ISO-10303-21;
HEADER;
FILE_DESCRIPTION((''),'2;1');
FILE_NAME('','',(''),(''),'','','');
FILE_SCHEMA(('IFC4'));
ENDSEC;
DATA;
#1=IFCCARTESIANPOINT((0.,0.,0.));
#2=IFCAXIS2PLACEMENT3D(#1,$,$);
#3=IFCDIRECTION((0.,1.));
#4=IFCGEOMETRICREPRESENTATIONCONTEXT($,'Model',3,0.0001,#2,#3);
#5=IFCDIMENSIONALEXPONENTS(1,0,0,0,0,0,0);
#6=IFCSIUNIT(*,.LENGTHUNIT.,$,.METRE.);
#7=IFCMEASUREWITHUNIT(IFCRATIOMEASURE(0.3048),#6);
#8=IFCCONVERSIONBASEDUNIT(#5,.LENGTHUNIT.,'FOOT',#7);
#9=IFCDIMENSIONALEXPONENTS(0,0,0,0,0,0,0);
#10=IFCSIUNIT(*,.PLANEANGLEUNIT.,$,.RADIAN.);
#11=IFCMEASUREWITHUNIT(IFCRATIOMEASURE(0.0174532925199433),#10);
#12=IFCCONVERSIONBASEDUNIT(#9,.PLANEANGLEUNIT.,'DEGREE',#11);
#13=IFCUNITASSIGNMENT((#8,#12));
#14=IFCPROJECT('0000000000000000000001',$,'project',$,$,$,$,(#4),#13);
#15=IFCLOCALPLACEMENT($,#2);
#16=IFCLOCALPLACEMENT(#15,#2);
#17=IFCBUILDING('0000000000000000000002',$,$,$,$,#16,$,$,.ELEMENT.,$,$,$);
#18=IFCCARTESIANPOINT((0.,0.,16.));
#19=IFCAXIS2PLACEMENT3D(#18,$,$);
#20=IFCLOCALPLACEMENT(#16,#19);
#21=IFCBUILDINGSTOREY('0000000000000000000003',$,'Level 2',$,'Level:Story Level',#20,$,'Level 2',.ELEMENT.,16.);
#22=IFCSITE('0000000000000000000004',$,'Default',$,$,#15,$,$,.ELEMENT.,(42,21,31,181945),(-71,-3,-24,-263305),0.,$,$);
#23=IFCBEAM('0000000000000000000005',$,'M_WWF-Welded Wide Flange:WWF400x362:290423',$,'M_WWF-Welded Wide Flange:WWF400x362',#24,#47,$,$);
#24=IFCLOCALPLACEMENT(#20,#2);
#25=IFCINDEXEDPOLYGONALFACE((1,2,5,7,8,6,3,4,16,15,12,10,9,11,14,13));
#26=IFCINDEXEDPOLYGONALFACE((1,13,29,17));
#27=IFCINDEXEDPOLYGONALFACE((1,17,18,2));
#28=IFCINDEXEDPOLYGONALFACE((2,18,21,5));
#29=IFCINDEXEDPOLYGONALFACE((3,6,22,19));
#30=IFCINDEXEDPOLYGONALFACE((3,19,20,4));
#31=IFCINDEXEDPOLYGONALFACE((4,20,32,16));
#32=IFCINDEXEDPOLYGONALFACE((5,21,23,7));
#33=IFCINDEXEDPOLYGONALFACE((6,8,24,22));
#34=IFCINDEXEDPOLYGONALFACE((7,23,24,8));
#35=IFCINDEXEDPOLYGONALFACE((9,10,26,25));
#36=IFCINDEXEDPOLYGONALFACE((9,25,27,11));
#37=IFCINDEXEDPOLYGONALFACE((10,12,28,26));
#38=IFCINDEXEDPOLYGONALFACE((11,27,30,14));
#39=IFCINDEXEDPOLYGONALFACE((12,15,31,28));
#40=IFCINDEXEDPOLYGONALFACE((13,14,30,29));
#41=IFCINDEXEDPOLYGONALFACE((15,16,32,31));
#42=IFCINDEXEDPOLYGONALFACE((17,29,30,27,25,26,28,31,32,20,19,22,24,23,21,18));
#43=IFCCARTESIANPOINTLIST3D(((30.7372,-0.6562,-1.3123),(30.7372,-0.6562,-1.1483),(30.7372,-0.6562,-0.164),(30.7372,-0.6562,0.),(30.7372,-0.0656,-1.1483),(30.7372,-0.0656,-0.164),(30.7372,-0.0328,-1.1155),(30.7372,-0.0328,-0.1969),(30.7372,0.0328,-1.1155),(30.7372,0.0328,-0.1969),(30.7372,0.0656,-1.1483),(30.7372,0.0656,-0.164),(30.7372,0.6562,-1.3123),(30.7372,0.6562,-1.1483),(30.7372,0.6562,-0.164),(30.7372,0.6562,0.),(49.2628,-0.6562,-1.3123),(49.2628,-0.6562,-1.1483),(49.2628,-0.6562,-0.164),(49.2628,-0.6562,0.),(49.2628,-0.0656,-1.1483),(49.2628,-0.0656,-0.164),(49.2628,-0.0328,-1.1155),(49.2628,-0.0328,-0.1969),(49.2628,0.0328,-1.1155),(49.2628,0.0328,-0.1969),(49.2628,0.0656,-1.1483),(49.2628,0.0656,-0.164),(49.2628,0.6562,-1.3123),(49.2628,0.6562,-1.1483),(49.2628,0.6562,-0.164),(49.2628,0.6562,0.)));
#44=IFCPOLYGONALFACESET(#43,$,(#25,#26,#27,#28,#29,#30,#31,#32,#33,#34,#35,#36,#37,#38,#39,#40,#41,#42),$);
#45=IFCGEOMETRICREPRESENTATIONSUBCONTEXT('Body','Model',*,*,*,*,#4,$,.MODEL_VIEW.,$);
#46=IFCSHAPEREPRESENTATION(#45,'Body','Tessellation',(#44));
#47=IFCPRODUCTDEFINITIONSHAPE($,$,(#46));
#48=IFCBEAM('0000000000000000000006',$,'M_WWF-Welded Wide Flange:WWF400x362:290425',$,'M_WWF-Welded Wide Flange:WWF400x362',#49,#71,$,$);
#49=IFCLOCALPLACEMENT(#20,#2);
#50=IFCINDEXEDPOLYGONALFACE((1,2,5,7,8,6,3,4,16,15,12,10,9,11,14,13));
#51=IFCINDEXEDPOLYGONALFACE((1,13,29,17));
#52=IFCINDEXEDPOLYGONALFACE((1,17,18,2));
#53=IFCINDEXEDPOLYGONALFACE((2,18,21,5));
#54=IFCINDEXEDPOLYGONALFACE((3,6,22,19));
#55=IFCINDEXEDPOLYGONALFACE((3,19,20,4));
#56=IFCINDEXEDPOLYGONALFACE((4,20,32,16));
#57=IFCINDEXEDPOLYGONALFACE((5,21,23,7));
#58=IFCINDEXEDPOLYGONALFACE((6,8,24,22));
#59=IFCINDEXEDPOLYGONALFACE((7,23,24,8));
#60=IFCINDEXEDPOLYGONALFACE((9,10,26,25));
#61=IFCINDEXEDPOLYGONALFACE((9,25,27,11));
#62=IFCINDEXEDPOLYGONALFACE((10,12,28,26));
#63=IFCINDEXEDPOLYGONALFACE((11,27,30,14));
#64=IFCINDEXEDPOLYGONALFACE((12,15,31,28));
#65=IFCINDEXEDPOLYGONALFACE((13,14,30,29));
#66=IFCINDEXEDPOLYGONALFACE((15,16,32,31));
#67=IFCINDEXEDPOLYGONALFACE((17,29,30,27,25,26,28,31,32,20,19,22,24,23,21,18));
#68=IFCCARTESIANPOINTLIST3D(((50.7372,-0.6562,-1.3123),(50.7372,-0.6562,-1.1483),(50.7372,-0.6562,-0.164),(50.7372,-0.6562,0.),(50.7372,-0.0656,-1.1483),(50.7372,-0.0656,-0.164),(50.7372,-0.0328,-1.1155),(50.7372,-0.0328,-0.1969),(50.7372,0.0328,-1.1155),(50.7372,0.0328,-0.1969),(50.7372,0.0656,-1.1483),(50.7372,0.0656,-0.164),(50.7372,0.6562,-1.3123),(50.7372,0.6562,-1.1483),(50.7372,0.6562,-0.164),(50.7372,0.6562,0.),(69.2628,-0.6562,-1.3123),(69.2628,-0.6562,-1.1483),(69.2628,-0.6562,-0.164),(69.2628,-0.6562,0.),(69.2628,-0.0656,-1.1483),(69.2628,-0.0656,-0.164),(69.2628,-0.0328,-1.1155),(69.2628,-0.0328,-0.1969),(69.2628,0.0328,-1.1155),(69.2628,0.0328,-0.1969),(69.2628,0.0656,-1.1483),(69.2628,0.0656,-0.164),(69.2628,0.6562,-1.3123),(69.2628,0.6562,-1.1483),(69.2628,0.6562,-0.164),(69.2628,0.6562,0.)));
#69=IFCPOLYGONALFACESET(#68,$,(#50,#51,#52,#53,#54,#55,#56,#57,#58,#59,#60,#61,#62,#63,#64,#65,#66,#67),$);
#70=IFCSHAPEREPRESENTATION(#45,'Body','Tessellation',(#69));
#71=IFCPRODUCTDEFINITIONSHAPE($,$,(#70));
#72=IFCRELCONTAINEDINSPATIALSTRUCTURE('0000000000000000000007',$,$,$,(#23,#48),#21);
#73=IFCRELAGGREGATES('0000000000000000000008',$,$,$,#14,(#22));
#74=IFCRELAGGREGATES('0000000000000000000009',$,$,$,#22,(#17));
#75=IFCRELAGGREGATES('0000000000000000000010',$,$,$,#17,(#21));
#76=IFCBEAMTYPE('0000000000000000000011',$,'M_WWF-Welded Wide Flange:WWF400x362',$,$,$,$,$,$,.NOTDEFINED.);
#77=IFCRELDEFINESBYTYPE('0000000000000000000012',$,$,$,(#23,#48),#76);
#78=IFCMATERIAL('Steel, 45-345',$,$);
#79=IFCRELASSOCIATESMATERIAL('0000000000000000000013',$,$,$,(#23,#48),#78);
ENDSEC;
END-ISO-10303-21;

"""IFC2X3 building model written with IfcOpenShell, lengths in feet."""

from ifc_helpers import new_model, entity, si_unit, converted_unit, direction, frame, origin, place, context, subcontext, project, spatial, polyline, outline, extrude, material, type_object, element, save


model = new_model("IFC2X3")

# Units and contexts
model_context = context("Model", 3, precision=0.0001, world=origin(), true_north=direction((0.0, 1.0)))
body_context = subcontext(model_context, "Body", "Model", "MODEL_VIEW")
ifc_project = project(units=[converted_unit("LENGTHUNIT", "FOOT", entity("IfcRatioMeasure", 0.3048), si_unit("LENGTHUNIT", "METRE"), dimensions=[1, 0, 0, 0, 0, 0, 0]), converted_unit("PLANEANGLEUNIT", "DEGREE", entity("IfcRatioMeasure", 0.0174532925199433), si_unit("PLANEANGLEUNIT", "RADIAN"), dimensions=[0, 0, 0, 0, 0, 0, 0])], contexts=[model_context])

# Site, building, storey
site_placement = place(None, origin())
site = spatial("IfcSite", under=ifc_project, at=site_placement, Name="Default", CompositionType="ELEMENT", RefLatitude=(42, 21, 31, 181945), RefLongitude=(-71, -3, -24, -263305), RefElevation=0.0)
building_placement = place(site_placement, origin())
building = spatial("IfcBuilding", under=site, at=building_placement, CompositionType="ELEMENT")
storey_placement = place(building_placement, frame((0.0, 0.0, 16.0)))
storey = spatial("IfcBuildingStorey", under=building, at=storey_placement, Name="Level 2", ObjectType="Level:Story Level", LongName="Level 2", CompositionType="ELEMENT", Elevation=16.0)

# Shared definitions
ifc_material = material(Name="Steel, 45-345")

# Beams
beam_type = type_object("IfcBeamType", Name="M_WWF-Welded Wide Flange:WWF400x362", PredefinedType="NOTDEFINED")
beam_1_placement = place(storey_placement, frame((30.0, 0.0, 0.0)))
element("IfcBeam", 1, at=beam_1_placement, inside=storey, type_object=beam_type, material=ifc_material, Name="M_WWF-Welded Wide Flange:WWF400x362:290423", ObjectType="M_WWF-Welded Wide Flange:WWF400x362", context=body_context, shape_type="SweptSolid", body=[
    extrude(outline(polyline([(-0.6562, -0.6562), (-0.4921, -0.6562), (-0.4921, -0.0656), (-0.4593, -0.0328), (0.4593, -0.0328), (0.4921, -0.0656), (0.4921, -0.6562), (0.6562, -0.6562), (0.6562, 0.6562), (0.4921, 0.6562), (0.4921, 0.0656), (0.4593, 0.0328), (-0.4593, 0.0328), (-0.4921, 0.0656), (-0.4921, 0.6562), (-0.6562, 0.6562), (-0.6562, -0.6562)])), frame((0.7372, 0.0, -0.6562), z_axis=(1.0, 0.0, 0.0), x_axis=(0.0, 0.0, -1.0)), (0.0, 0.0, 1.0), 18.5256),
])
beam_2_placement = place(storey_placement, frame((50.0, 0.0, 0.0)))
element("IfcBeam", 2, at=beam_2_placement, inside=storey, type_object=beam_type, material=ifc_material, Name="M_WWF-Welded Wide Flange:WWF400x362:290425", ObjectType="M_WWF-Welded Wide Flange:WWF400x362", context=body_context, shape_type="SweptSolid", body=[
    extrude(outline(polyline([(-0.6562, -0.6562), (-0.4921, -0.6562), (-0.4921, -0.0656), (-0.4593, -0.0328), (0.4593, -0.0328), (0.4921, -0.0656), (0.4921, -0.6562), (0.6562, -0.6562), (0.6562, 0.6562), (0.4921, 0.6562), (0.4921, 0.0656), (0.4593, 0.0328), (-0.4593, 0.0328), (-0.4921, 0.0656), (-0.4921, 0.6562), (-0.6562, 0.6562), (-0.6562, -0.6562)])), frame((0.7372, 0.0, -0.6562), z_axis=(1.0, 0.0, 0.0), x_axis=(0.0, 0.0, -1.0)), (0.0, 0.0, 1.0), 18.5256),
])

save(model, "model.ifc")
